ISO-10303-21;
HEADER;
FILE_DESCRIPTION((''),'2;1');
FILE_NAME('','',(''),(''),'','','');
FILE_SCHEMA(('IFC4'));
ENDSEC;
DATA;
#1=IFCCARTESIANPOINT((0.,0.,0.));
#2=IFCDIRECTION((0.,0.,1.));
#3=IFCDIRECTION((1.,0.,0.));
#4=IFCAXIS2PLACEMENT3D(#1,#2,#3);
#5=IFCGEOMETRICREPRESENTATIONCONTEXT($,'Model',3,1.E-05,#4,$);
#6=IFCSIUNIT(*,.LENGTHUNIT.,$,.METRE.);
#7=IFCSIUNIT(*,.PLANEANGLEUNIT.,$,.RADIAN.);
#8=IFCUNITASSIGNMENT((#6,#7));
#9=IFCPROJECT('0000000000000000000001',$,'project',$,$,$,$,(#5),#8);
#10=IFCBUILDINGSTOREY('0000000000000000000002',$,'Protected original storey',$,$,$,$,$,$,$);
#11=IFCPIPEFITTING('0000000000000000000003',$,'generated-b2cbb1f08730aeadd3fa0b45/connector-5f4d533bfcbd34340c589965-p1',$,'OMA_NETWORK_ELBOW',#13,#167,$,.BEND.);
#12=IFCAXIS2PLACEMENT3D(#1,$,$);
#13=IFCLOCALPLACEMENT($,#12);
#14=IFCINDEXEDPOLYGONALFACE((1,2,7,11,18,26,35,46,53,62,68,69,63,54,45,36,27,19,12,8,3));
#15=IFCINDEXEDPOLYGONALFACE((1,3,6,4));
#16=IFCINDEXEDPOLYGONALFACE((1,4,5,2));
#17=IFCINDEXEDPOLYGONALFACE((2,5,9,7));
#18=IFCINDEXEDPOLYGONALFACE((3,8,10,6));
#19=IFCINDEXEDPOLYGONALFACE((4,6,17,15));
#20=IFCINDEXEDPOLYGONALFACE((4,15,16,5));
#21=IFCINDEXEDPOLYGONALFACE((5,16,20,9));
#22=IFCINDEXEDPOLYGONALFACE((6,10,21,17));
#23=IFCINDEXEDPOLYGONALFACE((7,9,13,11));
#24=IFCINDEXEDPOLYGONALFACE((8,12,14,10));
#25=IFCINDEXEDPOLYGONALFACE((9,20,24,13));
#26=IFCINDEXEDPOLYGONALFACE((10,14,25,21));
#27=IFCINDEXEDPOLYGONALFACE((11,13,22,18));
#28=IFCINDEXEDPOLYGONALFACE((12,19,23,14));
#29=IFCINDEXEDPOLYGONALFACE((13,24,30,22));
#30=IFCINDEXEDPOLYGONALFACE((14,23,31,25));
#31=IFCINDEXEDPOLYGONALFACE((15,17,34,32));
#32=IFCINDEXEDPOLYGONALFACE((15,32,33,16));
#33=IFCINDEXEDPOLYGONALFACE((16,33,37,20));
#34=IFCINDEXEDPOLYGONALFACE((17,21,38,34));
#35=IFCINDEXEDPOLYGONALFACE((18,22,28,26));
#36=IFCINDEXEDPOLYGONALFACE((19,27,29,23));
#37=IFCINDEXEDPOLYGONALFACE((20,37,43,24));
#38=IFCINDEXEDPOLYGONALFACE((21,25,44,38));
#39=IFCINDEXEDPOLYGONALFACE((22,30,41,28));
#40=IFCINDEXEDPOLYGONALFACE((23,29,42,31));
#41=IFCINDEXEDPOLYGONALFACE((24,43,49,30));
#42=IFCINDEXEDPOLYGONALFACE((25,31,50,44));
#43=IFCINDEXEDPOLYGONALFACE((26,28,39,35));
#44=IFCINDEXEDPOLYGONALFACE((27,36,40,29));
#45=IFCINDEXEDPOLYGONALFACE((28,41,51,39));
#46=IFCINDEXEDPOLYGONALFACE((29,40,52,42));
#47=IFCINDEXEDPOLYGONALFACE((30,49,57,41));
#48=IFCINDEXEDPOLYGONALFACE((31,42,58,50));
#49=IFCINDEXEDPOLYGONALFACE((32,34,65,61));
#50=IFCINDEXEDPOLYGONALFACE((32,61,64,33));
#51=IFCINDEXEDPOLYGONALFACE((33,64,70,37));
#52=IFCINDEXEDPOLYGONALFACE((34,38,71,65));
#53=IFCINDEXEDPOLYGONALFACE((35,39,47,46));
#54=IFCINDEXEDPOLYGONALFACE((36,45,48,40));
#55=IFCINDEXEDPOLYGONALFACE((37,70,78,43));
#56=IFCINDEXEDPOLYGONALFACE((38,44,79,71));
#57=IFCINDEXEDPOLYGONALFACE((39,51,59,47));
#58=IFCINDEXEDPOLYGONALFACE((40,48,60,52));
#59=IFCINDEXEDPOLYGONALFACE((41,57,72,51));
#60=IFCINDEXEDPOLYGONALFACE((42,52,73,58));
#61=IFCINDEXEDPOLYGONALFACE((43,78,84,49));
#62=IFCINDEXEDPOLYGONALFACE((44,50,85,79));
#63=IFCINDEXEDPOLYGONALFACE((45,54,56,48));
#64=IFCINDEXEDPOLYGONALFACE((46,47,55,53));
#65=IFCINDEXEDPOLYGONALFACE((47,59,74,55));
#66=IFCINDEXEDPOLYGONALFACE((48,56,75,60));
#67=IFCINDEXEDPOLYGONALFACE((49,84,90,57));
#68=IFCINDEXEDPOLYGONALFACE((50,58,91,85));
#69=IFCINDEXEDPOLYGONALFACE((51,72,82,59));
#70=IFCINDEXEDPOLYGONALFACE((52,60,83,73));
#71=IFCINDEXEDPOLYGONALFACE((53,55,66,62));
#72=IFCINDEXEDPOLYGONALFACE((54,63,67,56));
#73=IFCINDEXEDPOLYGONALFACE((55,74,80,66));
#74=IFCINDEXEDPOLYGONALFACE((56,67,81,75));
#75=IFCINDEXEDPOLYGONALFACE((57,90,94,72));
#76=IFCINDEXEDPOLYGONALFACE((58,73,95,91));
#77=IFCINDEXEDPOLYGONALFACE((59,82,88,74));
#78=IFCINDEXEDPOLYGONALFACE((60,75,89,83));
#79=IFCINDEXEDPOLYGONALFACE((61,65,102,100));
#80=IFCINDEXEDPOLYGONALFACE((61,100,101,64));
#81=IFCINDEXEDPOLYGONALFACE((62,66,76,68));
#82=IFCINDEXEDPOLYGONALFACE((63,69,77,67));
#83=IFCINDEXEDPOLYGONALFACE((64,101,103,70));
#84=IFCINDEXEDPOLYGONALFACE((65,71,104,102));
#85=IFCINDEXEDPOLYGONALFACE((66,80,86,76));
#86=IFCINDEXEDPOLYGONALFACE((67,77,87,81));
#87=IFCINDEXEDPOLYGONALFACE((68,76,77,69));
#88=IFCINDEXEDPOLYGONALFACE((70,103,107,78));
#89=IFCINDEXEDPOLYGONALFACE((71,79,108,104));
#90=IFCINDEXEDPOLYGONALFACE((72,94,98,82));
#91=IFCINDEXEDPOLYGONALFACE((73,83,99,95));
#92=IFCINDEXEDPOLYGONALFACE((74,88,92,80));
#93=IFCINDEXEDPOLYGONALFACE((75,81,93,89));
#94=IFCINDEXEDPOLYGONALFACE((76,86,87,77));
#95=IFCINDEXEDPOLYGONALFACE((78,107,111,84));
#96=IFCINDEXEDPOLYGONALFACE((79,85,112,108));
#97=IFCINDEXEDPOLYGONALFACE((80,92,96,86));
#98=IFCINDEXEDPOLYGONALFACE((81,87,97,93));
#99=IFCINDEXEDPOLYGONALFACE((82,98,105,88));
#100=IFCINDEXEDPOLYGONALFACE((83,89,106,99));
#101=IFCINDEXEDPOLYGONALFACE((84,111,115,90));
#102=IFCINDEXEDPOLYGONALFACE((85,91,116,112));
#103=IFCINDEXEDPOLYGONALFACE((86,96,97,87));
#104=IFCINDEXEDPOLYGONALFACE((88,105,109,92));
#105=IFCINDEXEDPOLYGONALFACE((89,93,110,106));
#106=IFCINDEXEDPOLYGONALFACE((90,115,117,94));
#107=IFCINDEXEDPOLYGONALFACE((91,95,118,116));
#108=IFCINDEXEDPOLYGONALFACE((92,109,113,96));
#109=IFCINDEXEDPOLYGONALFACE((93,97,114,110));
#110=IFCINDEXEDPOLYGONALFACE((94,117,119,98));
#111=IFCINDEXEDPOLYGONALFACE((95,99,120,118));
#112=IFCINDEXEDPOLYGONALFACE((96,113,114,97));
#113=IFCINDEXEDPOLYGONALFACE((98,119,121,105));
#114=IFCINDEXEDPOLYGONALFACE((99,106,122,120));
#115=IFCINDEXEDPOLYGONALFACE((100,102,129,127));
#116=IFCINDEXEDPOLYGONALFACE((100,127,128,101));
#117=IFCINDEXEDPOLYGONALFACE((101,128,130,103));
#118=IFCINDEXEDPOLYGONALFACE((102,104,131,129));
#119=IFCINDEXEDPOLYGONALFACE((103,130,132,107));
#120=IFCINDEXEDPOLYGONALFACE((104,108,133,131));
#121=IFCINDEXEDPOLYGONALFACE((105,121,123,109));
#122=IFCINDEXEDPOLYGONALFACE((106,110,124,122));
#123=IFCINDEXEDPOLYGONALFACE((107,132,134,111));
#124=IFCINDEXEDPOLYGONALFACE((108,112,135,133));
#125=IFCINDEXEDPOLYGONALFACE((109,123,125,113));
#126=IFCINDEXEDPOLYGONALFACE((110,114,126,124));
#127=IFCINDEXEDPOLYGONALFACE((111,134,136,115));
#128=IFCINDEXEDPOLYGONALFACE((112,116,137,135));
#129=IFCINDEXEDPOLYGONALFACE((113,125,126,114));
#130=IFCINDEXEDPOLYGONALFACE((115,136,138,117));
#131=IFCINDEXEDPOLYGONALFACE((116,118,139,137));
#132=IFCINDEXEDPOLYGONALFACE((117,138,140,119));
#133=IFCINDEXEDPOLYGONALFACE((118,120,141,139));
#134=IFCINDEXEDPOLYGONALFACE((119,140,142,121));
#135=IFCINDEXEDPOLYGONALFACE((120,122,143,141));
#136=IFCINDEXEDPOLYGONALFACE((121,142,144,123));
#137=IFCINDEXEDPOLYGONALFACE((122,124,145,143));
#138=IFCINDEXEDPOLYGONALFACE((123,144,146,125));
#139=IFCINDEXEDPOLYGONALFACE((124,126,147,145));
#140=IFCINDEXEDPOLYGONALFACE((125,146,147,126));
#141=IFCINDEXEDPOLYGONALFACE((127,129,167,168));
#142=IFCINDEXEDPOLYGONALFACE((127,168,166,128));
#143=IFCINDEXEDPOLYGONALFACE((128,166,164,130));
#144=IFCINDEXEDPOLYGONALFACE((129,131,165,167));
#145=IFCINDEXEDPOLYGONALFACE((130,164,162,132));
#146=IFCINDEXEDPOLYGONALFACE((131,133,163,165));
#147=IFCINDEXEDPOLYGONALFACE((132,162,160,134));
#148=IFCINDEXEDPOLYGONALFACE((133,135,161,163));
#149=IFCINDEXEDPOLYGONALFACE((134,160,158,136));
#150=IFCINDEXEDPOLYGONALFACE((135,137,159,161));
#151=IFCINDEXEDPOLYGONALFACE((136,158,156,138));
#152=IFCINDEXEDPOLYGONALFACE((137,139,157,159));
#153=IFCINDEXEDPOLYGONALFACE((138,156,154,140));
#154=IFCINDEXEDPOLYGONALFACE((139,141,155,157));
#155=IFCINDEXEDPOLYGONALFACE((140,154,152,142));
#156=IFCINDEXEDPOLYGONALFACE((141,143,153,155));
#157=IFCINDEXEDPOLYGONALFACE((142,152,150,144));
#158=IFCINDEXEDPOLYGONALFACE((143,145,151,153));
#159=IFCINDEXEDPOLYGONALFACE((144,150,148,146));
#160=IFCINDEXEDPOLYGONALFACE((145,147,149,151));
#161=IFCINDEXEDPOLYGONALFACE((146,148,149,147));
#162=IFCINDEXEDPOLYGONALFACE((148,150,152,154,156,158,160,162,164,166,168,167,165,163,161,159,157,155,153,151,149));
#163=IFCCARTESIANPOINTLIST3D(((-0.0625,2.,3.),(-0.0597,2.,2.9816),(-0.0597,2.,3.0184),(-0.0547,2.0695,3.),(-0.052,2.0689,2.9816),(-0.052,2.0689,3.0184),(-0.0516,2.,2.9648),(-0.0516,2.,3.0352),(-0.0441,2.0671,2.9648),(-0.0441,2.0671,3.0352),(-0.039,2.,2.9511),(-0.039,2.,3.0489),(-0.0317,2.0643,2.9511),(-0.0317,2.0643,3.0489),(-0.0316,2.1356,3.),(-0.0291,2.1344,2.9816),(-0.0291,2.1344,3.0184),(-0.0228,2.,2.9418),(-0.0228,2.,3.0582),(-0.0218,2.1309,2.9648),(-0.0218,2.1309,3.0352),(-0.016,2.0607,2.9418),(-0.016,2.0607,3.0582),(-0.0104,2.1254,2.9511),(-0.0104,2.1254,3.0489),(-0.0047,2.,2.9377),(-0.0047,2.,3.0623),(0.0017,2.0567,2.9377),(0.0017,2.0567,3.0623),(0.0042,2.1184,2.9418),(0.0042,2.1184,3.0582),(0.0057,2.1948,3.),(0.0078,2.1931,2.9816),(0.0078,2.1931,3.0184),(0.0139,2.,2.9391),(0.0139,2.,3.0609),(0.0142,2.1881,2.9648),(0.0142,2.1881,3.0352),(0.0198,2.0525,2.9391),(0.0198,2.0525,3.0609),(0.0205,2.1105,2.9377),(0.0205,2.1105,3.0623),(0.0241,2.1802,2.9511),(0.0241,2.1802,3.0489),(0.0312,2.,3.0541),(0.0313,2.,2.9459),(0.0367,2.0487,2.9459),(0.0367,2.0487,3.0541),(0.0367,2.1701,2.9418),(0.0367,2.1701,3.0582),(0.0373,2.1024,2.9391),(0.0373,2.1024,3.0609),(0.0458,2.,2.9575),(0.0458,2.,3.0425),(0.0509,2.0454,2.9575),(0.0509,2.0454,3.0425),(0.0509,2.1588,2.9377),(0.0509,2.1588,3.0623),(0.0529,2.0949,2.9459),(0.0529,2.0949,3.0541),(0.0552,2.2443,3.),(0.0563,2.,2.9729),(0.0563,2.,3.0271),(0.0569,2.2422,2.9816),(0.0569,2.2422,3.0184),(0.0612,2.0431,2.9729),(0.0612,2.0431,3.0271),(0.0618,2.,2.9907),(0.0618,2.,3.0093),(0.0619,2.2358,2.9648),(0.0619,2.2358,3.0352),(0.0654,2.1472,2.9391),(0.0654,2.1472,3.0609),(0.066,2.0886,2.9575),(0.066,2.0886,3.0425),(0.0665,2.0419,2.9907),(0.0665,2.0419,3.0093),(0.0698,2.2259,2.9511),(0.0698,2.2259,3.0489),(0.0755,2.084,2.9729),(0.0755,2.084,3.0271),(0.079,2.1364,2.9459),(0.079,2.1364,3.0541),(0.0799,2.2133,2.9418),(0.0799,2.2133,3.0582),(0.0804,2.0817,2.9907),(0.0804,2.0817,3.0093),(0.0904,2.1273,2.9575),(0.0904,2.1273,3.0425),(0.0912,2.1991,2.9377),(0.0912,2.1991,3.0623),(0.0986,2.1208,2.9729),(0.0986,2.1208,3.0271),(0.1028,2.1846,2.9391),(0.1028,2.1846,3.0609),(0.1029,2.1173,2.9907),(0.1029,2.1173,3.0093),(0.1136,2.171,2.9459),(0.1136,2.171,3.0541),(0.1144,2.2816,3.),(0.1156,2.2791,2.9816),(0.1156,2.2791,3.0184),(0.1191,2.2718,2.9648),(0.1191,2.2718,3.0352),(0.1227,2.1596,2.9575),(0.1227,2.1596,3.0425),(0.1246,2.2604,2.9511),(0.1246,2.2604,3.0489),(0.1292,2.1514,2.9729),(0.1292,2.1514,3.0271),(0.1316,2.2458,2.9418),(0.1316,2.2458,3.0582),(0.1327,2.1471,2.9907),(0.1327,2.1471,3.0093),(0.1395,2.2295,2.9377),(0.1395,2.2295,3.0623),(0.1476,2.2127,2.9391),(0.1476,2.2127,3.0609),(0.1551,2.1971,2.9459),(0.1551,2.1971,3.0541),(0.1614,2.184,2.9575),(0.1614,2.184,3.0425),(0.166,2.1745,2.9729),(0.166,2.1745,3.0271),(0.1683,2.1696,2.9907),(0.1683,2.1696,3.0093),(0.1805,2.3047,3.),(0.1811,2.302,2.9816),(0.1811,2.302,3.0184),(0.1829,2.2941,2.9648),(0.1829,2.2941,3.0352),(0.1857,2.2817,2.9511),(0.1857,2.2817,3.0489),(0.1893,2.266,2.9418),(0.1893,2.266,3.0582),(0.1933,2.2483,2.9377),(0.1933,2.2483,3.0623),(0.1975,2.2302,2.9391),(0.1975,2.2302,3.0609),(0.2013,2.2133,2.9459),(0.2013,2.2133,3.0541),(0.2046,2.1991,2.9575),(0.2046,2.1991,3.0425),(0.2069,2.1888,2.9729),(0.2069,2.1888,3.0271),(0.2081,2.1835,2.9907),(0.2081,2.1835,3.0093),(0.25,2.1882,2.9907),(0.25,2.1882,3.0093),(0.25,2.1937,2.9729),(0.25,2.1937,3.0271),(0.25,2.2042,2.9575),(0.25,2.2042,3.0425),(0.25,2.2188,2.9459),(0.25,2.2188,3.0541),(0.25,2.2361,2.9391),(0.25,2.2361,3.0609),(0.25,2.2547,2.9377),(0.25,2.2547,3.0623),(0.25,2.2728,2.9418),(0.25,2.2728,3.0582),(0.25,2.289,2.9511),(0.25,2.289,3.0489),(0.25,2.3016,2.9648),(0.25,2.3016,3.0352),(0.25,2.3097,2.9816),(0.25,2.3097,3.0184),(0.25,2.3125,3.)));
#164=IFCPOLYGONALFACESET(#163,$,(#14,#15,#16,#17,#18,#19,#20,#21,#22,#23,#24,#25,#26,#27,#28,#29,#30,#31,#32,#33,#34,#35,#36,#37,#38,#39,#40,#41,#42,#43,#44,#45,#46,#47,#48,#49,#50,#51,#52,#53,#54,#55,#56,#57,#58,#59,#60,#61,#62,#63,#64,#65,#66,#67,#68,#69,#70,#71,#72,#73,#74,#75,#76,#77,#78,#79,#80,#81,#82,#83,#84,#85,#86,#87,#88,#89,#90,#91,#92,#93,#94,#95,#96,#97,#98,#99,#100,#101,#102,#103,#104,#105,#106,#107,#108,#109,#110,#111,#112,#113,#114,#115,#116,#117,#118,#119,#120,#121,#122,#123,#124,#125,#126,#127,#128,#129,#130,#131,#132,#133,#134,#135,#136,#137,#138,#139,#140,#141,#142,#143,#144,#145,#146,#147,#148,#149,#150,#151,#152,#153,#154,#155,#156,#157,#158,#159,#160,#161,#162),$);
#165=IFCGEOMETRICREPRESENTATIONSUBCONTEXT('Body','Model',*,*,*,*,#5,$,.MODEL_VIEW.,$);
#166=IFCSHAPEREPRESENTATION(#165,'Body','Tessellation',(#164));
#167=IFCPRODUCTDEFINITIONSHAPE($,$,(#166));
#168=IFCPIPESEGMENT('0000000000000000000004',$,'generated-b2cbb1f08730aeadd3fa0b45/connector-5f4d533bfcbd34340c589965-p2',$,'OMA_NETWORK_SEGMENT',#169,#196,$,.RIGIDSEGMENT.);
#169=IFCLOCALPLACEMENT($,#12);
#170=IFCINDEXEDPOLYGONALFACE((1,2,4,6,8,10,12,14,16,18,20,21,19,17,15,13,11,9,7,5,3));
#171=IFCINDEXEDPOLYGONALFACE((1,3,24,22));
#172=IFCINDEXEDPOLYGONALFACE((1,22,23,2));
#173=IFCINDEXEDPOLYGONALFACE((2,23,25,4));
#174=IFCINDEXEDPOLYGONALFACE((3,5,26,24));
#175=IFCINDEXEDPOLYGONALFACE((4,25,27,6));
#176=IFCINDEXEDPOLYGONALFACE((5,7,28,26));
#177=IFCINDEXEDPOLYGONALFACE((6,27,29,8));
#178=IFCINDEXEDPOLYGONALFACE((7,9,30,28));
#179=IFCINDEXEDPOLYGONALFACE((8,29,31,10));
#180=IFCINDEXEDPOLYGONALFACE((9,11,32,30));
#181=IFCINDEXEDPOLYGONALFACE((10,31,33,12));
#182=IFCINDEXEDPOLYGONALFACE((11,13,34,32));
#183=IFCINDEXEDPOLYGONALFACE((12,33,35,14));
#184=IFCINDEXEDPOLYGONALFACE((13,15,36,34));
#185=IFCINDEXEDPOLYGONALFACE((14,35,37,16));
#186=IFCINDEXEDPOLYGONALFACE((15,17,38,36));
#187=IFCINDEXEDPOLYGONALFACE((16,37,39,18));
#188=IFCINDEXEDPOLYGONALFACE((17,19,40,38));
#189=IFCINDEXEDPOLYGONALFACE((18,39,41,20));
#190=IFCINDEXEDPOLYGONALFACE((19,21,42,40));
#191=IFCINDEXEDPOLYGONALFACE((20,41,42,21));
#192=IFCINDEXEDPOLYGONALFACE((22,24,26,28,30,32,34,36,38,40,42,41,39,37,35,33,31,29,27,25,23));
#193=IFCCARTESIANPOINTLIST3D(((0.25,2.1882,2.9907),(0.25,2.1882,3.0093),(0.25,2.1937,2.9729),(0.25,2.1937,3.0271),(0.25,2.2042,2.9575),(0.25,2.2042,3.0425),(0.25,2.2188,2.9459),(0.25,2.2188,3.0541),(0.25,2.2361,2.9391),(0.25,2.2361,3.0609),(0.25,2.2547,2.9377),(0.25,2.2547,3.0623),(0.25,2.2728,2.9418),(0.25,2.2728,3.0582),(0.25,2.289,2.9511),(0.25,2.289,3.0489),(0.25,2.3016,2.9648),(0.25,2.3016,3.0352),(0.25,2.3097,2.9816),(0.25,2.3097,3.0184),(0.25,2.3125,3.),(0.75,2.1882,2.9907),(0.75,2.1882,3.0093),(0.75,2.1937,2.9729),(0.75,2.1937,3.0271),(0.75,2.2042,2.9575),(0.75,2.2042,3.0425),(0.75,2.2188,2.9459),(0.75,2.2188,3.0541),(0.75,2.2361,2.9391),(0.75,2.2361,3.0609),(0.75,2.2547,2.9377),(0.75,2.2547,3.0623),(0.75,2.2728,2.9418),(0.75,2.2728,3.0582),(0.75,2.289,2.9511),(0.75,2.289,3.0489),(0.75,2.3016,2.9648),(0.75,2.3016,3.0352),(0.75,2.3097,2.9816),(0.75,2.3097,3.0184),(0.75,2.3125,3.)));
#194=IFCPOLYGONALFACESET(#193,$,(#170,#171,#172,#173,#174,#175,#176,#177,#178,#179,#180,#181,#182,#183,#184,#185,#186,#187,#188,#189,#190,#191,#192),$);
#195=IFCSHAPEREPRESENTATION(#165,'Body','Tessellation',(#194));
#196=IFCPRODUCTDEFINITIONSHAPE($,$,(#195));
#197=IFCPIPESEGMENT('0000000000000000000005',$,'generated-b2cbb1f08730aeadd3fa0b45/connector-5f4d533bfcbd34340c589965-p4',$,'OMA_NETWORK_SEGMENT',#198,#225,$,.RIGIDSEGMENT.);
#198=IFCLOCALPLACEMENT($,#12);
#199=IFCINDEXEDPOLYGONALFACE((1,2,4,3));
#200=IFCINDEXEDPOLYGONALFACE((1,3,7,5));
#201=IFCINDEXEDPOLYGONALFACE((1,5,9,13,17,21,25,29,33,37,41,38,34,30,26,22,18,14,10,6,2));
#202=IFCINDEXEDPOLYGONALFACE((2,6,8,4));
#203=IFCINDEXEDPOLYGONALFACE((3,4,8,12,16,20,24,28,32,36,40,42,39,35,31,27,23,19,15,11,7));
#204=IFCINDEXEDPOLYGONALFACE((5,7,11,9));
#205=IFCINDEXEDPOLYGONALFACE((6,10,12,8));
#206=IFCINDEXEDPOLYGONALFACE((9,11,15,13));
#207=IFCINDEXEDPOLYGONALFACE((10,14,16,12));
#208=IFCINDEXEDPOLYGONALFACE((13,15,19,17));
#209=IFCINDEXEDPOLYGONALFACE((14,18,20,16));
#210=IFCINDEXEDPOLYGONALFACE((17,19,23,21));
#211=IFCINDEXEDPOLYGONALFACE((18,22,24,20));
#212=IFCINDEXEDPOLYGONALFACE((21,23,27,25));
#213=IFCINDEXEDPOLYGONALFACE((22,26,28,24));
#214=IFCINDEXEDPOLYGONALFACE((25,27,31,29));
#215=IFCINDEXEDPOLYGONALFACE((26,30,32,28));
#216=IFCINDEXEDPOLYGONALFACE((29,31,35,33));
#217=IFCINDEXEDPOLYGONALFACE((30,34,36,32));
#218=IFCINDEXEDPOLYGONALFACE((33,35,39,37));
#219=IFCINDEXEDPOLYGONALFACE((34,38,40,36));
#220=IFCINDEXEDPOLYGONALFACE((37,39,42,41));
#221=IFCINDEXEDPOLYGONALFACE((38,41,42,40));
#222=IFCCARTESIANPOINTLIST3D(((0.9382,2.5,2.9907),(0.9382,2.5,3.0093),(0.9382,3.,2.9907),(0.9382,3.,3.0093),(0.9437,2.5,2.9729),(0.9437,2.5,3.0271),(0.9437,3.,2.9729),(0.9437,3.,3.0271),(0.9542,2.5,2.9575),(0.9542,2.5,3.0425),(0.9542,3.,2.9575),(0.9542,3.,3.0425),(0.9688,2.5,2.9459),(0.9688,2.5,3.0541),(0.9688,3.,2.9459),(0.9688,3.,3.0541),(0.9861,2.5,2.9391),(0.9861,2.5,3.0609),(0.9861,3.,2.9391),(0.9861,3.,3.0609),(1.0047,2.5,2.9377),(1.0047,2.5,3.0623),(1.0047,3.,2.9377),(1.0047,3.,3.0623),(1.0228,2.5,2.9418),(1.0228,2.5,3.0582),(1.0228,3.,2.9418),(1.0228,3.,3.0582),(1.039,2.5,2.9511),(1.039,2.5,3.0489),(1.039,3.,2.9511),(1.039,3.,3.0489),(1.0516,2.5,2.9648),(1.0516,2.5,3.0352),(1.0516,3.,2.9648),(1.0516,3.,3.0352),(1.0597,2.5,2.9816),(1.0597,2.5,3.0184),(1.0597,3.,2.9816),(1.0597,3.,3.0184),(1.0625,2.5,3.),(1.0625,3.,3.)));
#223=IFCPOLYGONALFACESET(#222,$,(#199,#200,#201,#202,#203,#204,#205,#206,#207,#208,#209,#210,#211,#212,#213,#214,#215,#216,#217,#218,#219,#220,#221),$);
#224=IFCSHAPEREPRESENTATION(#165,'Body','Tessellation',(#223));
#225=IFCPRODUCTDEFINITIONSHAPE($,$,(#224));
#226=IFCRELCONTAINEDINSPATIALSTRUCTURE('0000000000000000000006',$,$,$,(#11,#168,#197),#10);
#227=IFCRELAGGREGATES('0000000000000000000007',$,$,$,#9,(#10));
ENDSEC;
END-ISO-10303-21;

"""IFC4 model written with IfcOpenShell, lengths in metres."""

from ifc_helpers import new_model, entity, si_unit, frame, origin_with_axes, origin_2d, place, context, subcontext, project, spatial, circle, extrude, element, save


model = new_model("IFC4")

# Units and contexts
model_context = context("Model", 3, precision=1e-05, world=origin_with_axes())
body_context = subcontext(model_context, "Body", "Model", "MODEL_VIEW")
ifc_project = project(units=[si_unit("LENGTHUNIT", "METRE"), si_unit("PLANEANGLEUNIT", "RADIAN")], contexts=[model_context])

# Storey
storey = spatial("IfcBuildingStorey", under=ifc_project, Name="Protected original storey")

# Pipe fitting
pipe_fitting_1_placement = place(None, origin_with_axes())
element("IfcPipeFitting", 1, at=pipe_fitting_1_placement, inside=storey, Name="generated-b2cbb1f08730aeadd3fa0b45/connector-5f4d533bfcbd34340c589965-p1", ObjectType="OMA_NETWORK_ELBOW", PredefinedType="BEND", context=body_context, shape_type="SweptSolid", body=[
    entity("IfcRevolvedAreaSolid", entity("IfcCircleProfileDef", "AREA", None, entity("IfcAxis2Placement2D", entity("IfcCartesianPoint", [0.25, 0.0])), 0.0625), entity("IfcAxis2Placement3D", entity("IfcCartesianPoint", [0.25, 2.0, 3.0]), entity("IfcDirection", [0.0, 1.0, 0.0]), entity("IfcDirection", [-1.0, 0.0, 0.0])), entity("IfcAxis1Placement", entity("IfcCartesianPoint", [0.0, 0.0, 0.0]), entity("IfcDirection", [0.0, -1.0, 0.0])), 1.570796),
])

# Pipe segment
pipe_segment_1_placement = place(None, origin_with_axes())
element("IfcPipeSegment", 2, at=pipe_segment_1_placement, inside=storey, Name="generated-b2cbb1f08730aeadd3fa0b45/connector-5f4d533bfcbd34340c589965-p2", ObjectType="OMA_NETWORK_SEGMENT", PredefinedType="RIGIDSEGMENT", context=body_context, shape_type="SweptSolid", body=[
    extrude(circle(Radius=0.0625, at=origin_2d()), frame((0.25, 2.25, 3.0), z_axis=(1.0, 0.0, 0.0), x_axis=(0.0, 1.0, 0.0)), (0.0, 0.0, 1.0), 0.5),
])

# Pipe segment
pipe_segment_2_placement = place(None, origin_with_axes())
element("IfcPipeSegment", 3, at=pipe_segment_2_placement, inside=storey, Name="generated-b2cbb1f08730aeadd3fa0b45/connector-5f4d533bfcbd34340c589965-p4", ObjectType="OMA_NETWORK_SEGMENT", PredefinedType="RIGIDSEGMENT", context=body_context, shape_type="SweptSolid", body=[
    extrude(circle(Radius=0.0625, at=origin_2d()), frame((1.0, 2.5, 3.0), z_axis=(0.0, 1.0, 0.0), x_axis=(1.0, 0.0, 0.0)), (0.0, 0.0, 1.0), 0.5),
])

save(model, "model.ifc")
